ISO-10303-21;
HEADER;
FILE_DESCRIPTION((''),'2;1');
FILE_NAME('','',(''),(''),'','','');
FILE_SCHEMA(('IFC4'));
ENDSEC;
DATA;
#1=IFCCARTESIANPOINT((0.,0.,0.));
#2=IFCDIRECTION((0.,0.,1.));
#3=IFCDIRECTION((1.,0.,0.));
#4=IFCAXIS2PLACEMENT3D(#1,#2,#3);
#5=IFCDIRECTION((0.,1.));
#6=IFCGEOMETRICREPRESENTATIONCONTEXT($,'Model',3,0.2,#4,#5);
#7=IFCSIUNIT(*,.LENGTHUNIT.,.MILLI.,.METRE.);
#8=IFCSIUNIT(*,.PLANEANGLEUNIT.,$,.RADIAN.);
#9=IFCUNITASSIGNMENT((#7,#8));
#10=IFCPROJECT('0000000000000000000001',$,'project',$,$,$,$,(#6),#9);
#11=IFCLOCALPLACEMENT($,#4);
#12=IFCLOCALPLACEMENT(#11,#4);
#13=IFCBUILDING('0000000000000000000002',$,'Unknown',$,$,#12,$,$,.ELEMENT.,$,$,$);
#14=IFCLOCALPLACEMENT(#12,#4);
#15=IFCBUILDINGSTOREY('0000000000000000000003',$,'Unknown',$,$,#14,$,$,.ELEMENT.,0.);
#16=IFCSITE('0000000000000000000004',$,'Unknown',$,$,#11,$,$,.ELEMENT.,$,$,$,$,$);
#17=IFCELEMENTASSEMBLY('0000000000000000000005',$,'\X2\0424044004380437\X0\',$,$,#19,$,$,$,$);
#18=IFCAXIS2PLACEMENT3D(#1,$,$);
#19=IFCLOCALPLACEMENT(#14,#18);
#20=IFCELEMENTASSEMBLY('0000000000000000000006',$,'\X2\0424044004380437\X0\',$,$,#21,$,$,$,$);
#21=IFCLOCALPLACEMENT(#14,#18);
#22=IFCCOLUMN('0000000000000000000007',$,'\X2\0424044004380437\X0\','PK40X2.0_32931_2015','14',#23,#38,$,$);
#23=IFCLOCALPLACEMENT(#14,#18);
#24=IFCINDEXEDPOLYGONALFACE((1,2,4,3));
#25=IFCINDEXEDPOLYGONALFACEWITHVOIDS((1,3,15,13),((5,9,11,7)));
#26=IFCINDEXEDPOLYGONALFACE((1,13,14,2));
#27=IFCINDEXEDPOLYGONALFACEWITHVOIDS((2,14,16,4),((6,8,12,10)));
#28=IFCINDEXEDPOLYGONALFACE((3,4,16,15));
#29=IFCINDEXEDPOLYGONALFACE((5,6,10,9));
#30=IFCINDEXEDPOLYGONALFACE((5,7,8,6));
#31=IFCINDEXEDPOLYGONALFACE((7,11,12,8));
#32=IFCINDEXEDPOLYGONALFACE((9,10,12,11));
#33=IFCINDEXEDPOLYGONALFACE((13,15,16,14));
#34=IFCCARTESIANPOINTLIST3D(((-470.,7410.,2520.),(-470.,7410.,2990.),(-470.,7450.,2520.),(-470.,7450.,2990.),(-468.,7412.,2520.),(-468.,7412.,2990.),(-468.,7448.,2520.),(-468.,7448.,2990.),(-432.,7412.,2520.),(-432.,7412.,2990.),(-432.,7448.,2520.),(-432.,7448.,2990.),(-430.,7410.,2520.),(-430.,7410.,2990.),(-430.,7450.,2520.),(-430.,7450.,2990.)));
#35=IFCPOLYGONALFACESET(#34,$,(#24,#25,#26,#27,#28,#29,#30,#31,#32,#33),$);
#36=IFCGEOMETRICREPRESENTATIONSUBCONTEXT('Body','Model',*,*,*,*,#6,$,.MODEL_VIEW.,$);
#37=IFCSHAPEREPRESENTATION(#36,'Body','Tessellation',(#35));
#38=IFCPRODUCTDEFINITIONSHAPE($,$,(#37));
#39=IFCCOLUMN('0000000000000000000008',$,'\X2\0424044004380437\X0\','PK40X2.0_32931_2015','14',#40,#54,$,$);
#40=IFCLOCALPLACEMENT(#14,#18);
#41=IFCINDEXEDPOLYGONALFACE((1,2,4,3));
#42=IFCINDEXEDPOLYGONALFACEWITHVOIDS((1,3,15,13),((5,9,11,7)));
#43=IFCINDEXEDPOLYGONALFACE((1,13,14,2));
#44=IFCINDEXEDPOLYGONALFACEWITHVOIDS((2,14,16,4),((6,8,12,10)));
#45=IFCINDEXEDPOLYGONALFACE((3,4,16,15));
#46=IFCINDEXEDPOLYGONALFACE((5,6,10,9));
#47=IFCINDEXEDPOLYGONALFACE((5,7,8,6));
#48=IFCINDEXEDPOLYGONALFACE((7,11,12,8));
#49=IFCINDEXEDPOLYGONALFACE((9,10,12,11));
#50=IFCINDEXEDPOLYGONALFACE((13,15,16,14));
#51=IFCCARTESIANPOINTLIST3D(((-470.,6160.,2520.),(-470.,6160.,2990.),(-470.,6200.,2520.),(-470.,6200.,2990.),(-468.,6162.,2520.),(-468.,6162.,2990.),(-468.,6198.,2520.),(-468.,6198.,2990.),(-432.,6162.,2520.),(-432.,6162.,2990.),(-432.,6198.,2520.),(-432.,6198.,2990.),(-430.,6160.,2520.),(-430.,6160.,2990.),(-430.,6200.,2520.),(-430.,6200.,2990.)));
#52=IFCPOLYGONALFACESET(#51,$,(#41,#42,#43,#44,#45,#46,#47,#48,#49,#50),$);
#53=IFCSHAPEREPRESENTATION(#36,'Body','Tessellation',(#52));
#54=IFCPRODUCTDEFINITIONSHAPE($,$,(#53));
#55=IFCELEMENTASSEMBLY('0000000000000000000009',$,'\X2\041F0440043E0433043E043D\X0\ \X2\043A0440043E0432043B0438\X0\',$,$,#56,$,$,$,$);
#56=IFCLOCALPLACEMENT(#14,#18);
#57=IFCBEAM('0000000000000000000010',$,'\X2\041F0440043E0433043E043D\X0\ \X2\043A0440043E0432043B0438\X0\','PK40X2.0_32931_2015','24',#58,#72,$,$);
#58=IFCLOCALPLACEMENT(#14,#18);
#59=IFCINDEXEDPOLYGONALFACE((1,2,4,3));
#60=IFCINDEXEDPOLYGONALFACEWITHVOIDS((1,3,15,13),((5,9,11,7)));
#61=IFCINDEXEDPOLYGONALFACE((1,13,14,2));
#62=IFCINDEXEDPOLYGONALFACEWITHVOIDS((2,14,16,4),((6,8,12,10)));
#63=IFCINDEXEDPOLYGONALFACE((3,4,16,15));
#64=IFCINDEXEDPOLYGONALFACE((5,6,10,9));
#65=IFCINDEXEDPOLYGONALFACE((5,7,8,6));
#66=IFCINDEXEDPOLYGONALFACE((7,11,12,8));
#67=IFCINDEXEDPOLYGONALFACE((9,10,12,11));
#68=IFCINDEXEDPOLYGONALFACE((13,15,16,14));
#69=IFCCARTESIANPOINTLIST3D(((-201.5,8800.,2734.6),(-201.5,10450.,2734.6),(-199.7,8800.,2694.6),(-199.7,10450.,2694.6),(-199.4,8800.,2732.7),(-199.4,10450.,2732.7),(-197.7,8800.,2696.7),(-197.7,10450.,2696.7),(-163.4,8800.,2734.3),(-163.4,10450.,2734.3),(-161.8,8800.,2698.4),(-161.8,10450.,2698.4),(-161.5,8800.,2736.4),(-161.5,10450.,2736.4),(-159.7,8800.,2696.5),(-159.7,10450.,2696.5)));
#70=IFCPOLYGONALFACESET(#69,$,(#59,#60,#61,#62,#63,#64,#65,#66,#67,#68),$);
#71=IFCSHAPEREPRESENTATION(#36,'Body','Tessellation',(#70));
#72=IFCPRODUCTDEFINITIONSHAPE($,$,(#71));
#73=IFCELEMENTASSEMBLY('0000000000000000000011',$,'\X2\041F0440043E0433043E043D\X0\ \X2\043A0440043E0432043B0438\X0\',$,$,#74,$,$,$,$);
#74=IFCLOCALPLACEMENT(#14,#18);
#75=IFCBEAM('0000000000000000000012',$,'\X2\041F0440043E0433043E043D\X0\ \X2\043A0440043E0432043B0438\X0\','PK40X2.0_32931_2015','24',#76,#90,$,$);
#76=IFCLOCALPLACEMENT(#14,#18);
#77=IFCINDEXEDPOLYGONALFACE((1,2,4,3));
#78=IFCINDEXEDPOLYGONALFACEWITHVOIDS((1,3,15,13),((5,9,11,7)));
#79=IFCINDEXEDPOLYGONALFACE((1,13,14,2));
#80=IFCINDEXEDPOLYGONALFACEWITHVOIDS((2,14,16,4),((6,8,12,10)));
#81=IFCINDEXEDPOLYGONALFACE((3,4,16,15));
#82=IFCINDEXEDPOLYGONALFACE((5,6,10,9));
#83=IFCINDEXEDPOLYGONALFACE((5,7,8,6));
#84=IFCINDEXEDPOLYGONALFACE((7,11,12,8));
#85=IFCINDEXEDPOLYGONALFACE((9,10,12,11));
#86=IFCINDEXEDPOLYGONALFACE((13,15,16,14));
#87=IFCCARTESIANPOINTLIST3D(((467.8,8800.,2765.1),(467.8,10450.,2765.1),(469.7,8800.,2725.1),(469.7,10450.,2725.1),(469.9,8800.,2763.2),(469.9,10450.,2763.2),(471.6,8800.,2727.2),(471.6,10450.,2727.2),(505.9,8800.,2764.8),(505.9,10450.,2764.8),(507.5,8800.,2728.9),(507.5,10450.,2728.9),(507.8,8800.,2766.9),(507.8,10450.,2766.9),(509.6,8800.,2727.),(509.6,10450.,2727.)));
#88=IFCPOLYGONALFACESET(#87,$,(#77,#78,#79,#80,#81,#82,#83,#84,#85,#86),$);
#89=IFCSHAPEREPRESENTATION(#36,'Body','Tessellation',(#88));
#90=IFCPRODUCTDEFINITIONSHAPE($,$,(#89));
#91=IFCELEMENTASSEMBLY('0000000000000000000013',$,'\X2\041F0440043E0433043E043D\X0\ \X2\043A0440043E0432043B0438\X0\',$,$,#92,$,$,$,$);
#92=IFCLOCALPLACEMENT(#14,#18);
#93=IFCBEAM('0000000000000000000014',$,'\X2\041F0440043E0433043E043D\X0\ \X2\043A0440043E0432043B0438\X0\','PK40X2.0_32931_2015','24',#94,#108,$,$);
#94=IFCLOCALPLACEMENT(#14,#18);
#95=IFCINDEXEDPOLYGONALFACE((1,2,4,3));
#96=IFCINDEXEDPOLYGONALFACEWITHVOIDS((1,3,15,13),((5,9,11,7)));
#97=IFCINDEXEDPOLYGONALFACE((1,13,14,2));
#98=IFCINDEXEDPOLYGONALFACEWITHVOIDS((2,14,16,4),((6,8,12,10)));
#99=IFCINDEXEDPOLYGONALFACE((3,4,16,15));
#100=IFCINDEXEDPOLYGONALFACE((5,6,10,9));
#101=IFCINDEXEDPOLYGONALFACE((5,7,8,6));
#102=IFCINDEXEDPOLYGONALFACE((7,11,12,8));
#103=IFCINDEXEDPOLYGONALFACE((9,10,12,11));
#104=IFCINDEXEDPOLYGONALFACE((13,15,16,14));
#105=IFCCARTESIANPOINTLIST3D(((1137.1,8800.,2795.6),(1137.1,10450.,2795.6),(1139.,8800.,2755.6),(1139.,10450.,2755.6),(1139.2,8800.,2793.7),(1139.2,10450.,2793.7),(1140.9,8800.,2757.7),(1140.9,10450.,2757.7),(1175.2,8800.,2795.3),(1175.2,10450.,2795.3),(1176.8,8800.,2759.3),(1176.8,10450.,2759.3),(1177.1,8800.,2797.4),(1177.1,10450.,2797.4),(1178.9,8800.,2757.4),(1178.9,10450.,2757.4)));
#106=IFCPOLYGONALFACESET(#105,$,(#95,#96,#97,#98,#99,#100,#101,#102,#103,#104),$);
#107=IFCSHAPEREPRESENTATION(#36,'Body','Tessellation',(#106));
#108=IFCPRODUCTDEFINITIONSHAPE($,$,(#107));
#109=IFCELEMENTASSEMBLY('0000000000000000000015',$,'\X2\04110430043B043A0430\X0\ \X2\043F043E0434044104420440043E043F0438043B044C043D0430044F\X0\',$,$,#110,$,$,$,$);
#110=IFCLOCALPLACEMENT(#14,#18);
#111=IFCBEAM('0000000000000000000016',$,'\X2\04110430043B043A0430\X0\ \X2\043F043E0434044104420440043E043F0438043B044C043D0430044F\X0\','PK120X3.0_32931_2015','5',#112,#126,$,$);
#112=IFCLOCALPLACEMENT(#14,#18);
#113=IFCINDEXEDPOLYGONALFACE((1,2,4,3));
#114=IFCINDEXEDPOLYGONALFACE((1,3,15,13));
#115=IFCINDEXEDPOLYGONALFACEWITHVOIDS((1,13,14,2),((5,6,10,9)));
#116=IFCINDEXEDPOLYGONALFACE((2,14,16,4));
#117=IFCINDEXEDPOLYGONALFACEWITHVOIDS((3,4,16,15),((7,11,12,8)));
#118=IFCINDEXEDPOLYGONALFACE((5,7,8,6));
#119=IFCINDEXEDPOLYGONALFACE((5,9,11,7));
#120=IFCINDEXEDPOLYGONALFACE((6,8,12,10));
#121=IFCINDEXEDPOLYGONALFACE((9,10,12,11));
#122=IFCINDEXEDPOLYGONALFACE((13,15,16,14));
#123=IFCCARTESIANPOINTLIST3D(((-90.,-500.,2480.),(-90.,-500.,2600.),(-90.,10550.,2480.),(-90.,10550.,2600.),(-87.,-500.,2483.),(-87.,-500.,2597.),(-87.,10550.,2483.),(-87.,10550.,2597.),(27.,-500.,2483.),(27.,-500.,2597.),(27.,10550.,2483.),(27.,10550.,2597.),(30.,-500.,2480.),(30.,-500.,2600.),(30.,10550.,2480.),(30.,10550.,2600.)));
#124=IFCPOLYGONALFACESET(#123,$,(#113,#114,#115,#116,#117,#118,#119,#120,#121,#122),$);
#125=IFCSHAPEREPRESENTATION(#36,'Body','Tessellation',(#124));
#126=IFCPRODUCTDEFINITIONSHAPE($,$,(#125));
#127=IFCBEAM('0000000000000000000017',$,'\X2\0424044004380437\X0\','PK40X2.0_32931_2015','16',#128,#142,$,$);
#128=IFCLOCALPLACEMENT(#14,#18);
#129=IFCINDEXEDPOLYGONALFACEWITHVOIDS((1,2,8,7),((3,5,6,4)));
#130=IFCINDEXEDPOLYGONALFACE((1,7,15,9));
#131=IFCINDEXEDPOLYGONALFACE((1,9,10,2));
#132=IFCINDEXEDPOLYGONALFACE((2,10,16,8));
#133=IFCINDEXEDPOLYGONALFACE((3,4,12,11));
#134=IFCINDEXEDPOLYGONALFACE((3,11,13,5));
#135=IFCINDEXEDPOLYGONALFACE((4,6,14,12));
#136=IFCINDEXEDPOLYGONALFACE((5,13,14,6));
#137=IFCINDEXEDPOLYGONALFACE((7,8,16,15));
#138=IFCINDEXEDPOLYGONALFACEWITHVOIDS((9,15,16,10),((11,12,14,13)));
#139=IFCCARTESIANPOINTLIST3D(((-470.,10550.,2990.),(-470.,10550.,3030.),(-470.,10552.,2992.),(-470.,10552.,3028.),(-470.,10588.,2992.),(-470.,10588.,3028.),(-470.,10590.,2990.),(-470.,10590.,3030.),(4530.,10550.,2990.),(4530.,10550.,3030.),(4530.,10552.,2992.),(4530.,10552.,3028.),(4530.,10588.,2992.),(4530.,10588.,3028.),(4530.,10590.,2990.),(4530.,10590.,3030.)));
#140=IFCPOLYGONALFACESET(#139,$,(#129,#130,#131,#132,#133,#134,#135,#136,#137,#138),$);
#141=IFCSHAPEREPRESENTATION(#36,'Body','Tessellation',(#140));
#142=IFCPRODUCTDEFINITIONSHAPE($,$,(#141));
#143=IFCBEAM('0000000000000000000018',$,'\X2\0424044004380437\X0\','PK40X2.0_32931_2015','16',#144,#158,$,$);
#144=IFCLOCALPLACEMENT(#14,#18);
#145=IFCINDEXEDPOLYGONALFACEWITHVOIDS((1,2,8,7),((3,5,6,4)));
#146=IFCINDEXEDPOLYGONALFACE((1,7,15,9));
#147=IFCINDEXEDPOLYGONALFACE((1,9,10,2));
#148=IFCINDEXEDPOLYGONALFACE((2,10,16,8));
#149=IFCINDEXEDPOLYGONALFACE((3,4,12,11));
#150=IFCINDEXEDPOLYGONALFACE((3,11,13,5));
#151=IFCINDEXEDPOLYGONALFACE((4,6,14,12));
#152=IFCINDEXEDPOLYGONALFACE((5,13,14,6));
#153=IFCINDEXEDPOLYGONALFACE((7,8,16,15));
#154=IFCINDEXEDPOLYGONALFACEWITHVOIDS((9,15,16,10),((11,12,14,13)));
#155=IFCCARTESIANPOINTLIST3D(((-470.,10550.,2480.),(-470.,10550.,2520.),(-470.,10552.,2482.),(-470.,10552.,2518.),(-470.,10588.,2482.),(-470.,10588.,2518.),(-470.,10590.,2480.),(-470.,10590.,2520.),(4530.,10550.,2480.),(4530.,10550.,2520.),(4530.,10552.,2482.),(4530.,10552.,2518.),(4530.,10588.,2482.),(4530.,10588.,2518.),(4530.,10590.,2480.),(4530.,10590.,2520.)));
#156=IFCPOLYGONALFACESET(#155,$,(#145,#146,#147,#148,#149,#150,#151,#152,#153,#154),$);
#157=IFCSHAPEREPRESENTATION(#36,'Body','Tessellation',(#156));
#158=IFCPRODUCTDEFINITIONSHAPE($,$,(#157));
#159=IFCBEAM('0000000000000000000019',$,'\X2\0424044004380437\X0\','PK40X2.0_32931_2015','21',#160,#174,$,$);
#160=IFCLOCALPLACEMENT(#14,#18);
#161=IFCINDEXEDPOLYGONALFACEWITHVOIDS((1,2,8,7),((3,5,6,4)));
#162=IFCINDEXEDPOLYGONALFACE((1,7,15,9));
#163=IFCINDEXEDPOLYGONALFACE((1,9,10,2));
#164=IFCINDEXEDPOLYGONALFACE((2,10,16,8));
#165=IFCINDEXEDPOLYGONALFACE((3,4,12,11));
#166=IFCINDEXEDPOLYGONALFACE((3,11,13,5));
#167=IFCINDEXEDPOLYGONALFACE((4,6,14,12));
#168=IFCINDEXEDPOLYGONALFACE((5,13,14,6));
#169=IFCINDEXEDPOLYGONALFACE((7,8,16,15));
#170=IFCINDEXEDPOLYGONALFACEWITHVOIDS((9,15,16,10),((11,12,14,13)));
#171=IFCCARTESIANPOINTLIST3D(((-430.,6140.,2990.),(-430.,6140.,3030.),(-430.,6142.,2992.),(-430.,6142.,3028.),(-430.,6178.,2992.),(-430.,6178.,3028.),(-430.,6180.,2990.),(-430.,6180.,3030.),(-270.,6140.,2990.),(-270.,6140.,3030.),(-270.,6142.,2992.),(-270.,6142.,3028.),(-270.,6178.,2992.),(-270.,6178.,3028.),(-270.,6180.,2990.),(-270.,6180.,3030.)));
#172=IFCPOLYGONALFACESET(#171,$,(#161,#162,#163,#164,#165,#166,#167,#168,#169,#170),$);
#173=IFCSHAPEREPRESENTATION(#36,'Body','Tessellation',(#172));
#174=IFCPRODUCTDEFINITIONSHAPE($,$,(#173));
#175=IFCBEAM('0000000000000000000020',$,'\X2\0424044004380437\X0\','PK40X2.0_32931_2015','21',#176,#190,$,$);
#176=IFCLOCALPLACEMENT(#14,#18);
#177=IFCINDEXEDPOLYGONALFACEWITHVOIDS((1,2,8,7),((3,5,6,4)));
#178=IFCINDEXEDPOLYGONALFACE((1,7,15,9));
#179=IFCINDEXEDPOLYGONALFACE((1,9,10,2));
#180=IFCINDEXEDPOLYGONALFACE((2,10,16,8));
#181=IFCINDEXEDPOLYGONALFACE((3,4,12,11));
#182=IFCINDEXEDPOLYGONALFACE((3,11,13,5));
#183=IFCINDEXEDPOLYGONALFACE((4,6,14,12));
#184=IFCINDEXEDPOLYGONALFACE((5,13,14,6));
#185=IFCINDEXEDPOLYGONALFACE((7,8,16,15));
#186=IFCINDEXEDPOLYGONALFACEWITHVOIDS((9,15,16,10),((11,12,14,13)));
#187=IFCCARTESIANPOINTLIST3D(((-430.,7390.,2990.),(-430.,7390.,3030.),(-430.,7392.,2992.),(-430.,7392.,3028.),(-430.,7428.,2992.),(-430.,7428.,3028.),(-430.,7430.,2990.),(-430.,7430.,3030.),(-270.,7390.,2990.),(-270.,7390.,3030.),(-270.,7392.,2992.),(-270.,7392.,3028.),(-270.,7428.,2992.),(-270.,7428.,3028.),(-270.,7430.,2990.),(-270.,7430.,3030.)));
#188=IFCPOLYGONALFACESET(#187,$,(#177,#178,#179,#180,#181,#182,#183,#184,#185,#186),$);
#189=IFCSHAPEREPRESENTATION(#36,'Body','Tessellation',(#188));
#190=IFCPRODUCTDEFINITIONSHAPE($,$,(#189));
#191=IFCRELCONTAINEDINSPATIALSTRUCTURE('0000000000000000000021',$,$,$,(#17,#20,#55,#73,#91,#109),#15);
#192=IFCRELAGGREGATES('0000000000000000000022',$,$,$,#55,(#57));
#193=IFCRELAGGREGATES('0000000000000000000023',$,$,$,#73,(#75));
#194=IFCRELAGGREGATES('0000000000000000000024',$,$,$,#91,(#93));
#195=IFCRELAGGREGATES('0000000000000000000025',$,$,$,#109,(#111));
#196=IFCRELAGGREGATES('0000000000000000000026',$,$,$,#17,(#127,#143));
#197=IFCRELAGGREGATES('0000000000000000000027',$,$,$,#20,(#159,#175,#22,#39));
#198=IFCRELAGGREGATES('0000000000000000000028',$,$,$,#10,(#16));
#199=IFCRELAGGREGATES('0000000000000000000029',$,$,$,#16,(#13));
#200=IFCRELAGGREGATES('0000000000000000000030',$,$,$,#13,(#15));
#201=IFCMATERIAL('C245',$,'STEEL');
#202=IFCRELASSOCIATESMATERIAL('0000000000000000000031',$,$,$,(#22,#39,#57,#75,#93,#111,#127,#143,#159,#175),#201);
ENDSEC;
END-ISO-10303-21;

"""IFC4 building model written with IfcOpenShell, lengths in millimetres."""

from ifc_helpers import new_model, si_unit, direction, frame, origin_with_axes, place, context, subcontext, project, spatial, line, indexed_curve, outline, extrude, material, element, aggregate, save


model = new_model("IFC4")

# Units and contexts
model_context = context("Model", 3, precision=0.2, world=origin_with_axes(), true_north=direction((0.0, 1.0)))
body_context = subcontext(model_context, "Body", "Model", "MODEL_VIEW")
ifc_project = project(units=[si_unit("LENGTHUNIT", "METRE", prefix="MILLI"), si_unit("PLANEANGLEUNIT", "RADIAN")], contexts=[model_context])

# Site, building, storey
site_placement = place(None, origin_with_axes())
site = spatial("IfcSite", under=ifc_project, at=site_placement, Name="Unknown", CompositionType="ELEMENT")
building_placement = place(site_placement, origin_with_axes())
building = spatial("IfcBuilding", under=site, at=building_placement, Name="Unknown", CompositionType="ELEMENT")
storey_placement = place(building_placement, origin_with_axes())
storey = spatial("IfcBuildingStorey", under=building, at=storey_placement, Name="Unknown", CompositionType="ELEMENT", Elevation=0.0)

# Shared definitions
ifc_material = material(Name="C245", Category="STEEL")

# Element assemblies, columns
assembly_1_placement = place(storey_placement, frame((-470.0, 10570.0, 3010.0), z_axis=(0.0, -1.0, 0.0), x_axis=(1.0, 0.0, 0.0)))
assembly_1 = element("IfcElementAssembly", 1, at=assembly_1_placement, inside=storey, Name="Фриз")
assembly_2_placement = place(storey_placement, frame((-450.0, -500.0, 3010.0), z_axis=(1.0, 0.0, 0.0), x_axis=(0.0, 1.0, 0.0)))
assembly_2 = element("IfcElementAssembly", 2, at=assembly_2_placement, inside=storey, Name="Фриз")
column_1_placement = place(assembly_2_placement, frame((7930.0, -490.0, 0.0), z_axis=(1.0, 0.0, 0.0), x_axis=(0.0, 1.0, 0.0)))
column_1 = element("IfcColumn", 3, at=column_1_placement, material=ifc_material, Name="Фриз", Description="PK40X2.0_32931_2015", ObjectType="14", context=body_context, shape_type="SolidModel", body=[
    extrude(outline(indexed_curve([(-20.0, -20.0), (20.0, -20.0), (20.0, 20.0), (-20.0, 20.0)], segments=[line(1, 2, 3, 4, 1)]), holes=[indexed_curve([(-18.0, -18.0), (-18.0, 18.0), (18.0, 18.0), (18.0, -18.0)], segments=[line(1, 2, 3, 4, 1)])]), frame((0.0, 0.0, 0.0), z_axis=(-1.0, 0.0, 0.0), x_axis=(0.0, 0.0, 1.0)), (0.0, 0.0, -1.0), 470.0),
])
column_2_placement = place(assembly_2_placement, frame((6680.0, -490.0, 0.0), z_axis=(1.0, 0.0, 0.0), x_axis=(0.0, 1.0, 0.0)))
column_2 = element("IfcColumn", 4, at=column_2_placement, material=ifc_material, Name="Фриз", Description="PK40X2.0_32931_2015", ObjectType="14", context=body_context, shape_type="SolidModel", body=[
    extrude(outline(indexed_curve([(-20.0, -20.0), (20.0, -20.0), (20.0, 20.0), (-20.0, 20.0)], segments=[line(1, 2, 3, 4, 1)]), holes=[indexed_curve([(-18.0, -18.0), (-18.0, 18.0), (18.0, 18.0), (18.0, -18.0)], segments=[line(1, 2, 3, 4, 1)])]), frame((0.0, 0.0, 0.0), z_axis=(-1.0, 0.0, 0.0), x_axis=(0.0, 0.0, 1.0)), (0.0, 0.0, -1.0), 470.0),
])

# Element assemblies, beams
assembly_3_placement = place(storey_placement, frame((-180.6, 10450.0, 2715.5), z_axis=(-0.998964, 0.0, -0.045508), x_axis=(0.0, -1.0, 0.0)))
assembly_3 = element("IfcElementAssembly", 5, at=assembly_3_placement, inside=storey, Name="Прогон кровли")
beam_1_placement = place(assembly_3_placement, origin_with_axes())
beam_1 = element("IfcBeam", 6, at=beam_1_placement, material=ifc_material, Name="Прогон кровли", Description="PK40X2.0_32931_2015", ObjectType="24", context=body_context, shape_type="SolidModel", body=[
    extrude(outline(indexed_curve([(-20.0, -20.0), (20.0, -20.0), (20.0, 20.0), (-20.0, 20.0)], segments=[line(1, 2, 3, 4, 1)]), holes=[indexed_curve([(-18.0, -18.0), (-18.0, 18.0), (18.0, 18.0), (18.0, -18.0)], segments=[line(1, 2, 3, 4, 1)])]), frame((0.0, 0.0, 0.0), z_axis=(-1.0, 0.0, 0.0), x_axis=(0.0, 0.0, 1.0)), (0.0, 0.0, -1.0), 1650.0),
])
aggregate(assembly_3, [beam_1])
assembly_4_placement = place(storey_placement, frame((488.7, 10450.0, 2746.0), z_axis=(-0.998964, 0.0, -0.045508), x_axis=(0.0, -1.0, 0.0)))
assembly_4 = element("IfcElementAssembly", 7, at=assembly_4_placement, inside=storey, Name="Прогон кровли")
beam_2_placement = place(assembly_4_placement, origin_with_axes())
beam_2 = element("IfcBeam", 8, at=beam_2_placement, material=ifc_material, Name="Прогон кровли", Description="PK40X2.0_32931_2015", ObjectType="24", context=body_context, shape_type="SolidModel", body=[
    extrude(outline(indexed_curve([(-20.0, -20.0), (20.0, -20.0), (20.0, 20.0), (-20.0, 20.0)], segments=[line(1, 2, 3, 4, 1)]), holes=[indexed_curve([(-18.0, -18.0), (-18.0, 18.0), (18.0, 18.0), (18.0, -18.0)], segments=[line(1, 2, 3, 4, 1)])]), frame((0.0, 0.0, 0.0), z_axis=(-1.0, 0.0, 0.0), x_axis=(0.0, 0.0, 1.0)), (0.0, 0.0, -1.0), 1650.0),
])
aggregate(assembly_4, [beam_2])
assembly_5_placement = place(storey_placement, frame((1158.0, 10450.0, 2776.5), z_axis=(-0.998964, 0.0, -0.045508), x_axis=(0.0, -1.0, 0.0)))
assembly_5 = element("IfcElementAssembly", 9, at=assembly_5_placement, inside=storey, Name="Прогон кровли")
beam_3_placement = place(assembly_5_placement, origin_with_axes())
beam_3 = element("IfcBeam", 10, at=beam_3_placement, material=ifc_material, Name="Прогон кровли", Description="PK40X2.0_32931_2015", ObjectType="24", context=body_context, shape_type="SolidModel", body=[
    extrude(outline(indexed_curve([(-20.0, -20.0), (20.0, -20.0), (20.0, 20.0), (-20.0, 20.0)], segments=[line(1, 2, 3, 4, 1)]), holes=[indexed_curve([(-18.0, -18.0), (-18.0, 18.0), (18.0, 18.0), (18.0, -18.0)], segments=[line(1, 2, 3, 4, 1)])]), frame((0.0, 0.0, 0.0), z_axis=(-1.0, 0.0, 0.0), x_axis=(0.0, 0.0, 1.0)), (0.0, 0.0, -1.0), 1650.0),
])
aggregate(assembly_5, [beam_3])
assembly_6_placement = place(storey_placement, frame((-30.0, 10550.0, 2540.0), z_axis=(-1.0, 0.0, 0.0), x_axis=(0.0, -1.0, 0.0)))
assembly_6 = element("IfcElementAssembly", 11, at=assembly_6_placement, inside=storey, Name="Балка подстропильная")
beam_4_placement = place(assembly_6_placement, origin_with_axes())
beam_4 = element("IfcBeam", 12, at=beam_4_placement, material=ifc_material, Name="Балка подстропильная", Description="PK120X3.0_32931_2015", ObjectType="5", context=body_context, shape_type="SolidModel", body=[
    extrude(outline(indexed_curve([(-60.0, -60.0), (60.0, -60.0), (60.0, 60.0), (-60.0, 60.0)], segments=[line(1, 2, 3, 4, 1)]), holes=[indexed_curve([(-57.0, -57.0), (-57.0, 57.0), (57.0, 57.0), (57.0, -57.0)], segments=[line(1, 2, 3, 4, 1)])]), frame((0.0, 0.0, 0.0), z_axis=(-1.0, 0.0, 0.0), x_axis=(0.0, 0.0, 1.0)), (0.0, 0.0, -1.0), 11050.0),
])
aggregate(assembly_6, [beam_4])

# Beams
beam_5_placement = place(assembly_1_placement, origin_with_axes())
beam_5 = element("IfcBeam", 13, at=beam_5_placement, material=ifc_material, Name="Фриз", Description="PK40X2.0_32931_2015", ObjectType="16", context=body_context, shape_type="SolidModel", body=[
    extrude(outline(indexed_curve([(-20.0, -20.0), (20.0, -20.0), (20.0, 20.0), (-20.0, 20.0)], segments=[line(1, 2, 3, 4, 1)]), holes=[indexed_curve([(-18.0, -18.0), (-18.0, 18.0), (18.0, 18.0), (18.0, -18.0)], segments=[line(1, 2, 3, 4, 1)])]), frame((0.0, 0.0, 0.0), z_axis=(-1.0, 0.0, 0.0), x_axis=(0.0, 0.0, 1.0)), (0.0, 0.0, -1.0), 5000.0),
])
beam_6_placement = place(assembly_1_placement, frame((0.0, -510.0, 0.0), z_axis=(0.0, 0.0, 1.0), x_axis=(1.0, 0.0, 0.0)))
beam_6 = element("IfcBeam", 14, at=beam_6_placement, material=ifc_material, Name="Фриз", Description="PK40X2.0_32931_2015", ObjectType="16", context=body_context, shape_type="SolidModel", body=[
    extrude(outline(indexed_curve([(-20.0, -20.0), (20.0, -20.0), (20.0, 20.0), (-20.0, 20.0)], segments=[line(1, 2, 3, 4, 1)]), holes=[indexed_curve([(-18.0, -18.0), (-18.0, 18.0), (18.0, 18.0), (18.0, -18.0)], segments=[line(1, 2, 3, 4, 1)])]), frame((0.0, 0.0, 0.0), z_axis=(-1.0, 0.0, 0.0), x_axis=(0.0, 0.0, 1.0)), (0.0, 0.0, -1.0), 5000.0),
])
aggregate(assembly_1, [beam_5, beam_6])
beam_7_placement = place(assembly_2_placement, frame((6660.0, 0.0, 20.0), z_axis=(-1.0, 0.0, 0.0), x_axis=(0.0, 0.0, 1.0)))
beam_7 = element("IfcBeam", 15, at=beam_7_placement, material=ifc_material, Name="Фриз", Description="PK40X2.0_32931_2015", ObjectType="21", context=body_context, shape_type="SolidModel", body=[
    extrude(outline(indexed_curve([(-20.0, -20.0), (20.0, -20.0), (20.0, 20.0), (-20.0, 20.0)], segments=[line(1, 2, 3, 4, 1)]), holes=[indexed_curve([(-18.0, -18.0), (-18.0, 18.0), (18.0, 18.0), (18.0, -18.0)], segments=[line(1, 2, 3, 4, 1)])]), frame((0.0, 0.0, 0.0), z_axis=(-1.0, 0.0, 0.0), x_axis=(0.0, 0.0, 1.0)), (0.0, 0.0, -1.0), 160.0),
])
beam_8_placement = place(assembly_2_placement, frame((7910.0, 0.0, 20.0), z_axis=(-1.0, 0.0, 0.0), x_axis=(0.0, 0.0, 1.0)))
beam_8 = element("IfcBeam", 16, at=beam_8_placement, material=ifc_material, Name="Фриз", Description="PK40X2.0_32931_2015", ObjectType="21", context=body_context, shape_type="SolidModel", body=[
    extrude(outline(indexed_curve([(-20.0, -20.0), (20.0, -20.0), (20.0, 20.0), (-20.0, 20.0)], segments=[line(1, 2, 3, 4, 1)]), holes=[indexed_curve([(-18.0, -18.0), (-18.0, 18.0), (18.0, 18.0), (18.0, -18.0)], segments=[line(1, 2, 3, 4, 1)])]), frame((0.0, 0.0, 0.0), z_axis=(-1.0, 0.0, 0.0), x_axis=(0.0, 0.0, 1.0)), (0.0, 0.0, -1.0), 160.0),
])
aggregate(assembly_2, [beam_7, beam_8, column_1, column_2])

save(model, "model.ifc")
